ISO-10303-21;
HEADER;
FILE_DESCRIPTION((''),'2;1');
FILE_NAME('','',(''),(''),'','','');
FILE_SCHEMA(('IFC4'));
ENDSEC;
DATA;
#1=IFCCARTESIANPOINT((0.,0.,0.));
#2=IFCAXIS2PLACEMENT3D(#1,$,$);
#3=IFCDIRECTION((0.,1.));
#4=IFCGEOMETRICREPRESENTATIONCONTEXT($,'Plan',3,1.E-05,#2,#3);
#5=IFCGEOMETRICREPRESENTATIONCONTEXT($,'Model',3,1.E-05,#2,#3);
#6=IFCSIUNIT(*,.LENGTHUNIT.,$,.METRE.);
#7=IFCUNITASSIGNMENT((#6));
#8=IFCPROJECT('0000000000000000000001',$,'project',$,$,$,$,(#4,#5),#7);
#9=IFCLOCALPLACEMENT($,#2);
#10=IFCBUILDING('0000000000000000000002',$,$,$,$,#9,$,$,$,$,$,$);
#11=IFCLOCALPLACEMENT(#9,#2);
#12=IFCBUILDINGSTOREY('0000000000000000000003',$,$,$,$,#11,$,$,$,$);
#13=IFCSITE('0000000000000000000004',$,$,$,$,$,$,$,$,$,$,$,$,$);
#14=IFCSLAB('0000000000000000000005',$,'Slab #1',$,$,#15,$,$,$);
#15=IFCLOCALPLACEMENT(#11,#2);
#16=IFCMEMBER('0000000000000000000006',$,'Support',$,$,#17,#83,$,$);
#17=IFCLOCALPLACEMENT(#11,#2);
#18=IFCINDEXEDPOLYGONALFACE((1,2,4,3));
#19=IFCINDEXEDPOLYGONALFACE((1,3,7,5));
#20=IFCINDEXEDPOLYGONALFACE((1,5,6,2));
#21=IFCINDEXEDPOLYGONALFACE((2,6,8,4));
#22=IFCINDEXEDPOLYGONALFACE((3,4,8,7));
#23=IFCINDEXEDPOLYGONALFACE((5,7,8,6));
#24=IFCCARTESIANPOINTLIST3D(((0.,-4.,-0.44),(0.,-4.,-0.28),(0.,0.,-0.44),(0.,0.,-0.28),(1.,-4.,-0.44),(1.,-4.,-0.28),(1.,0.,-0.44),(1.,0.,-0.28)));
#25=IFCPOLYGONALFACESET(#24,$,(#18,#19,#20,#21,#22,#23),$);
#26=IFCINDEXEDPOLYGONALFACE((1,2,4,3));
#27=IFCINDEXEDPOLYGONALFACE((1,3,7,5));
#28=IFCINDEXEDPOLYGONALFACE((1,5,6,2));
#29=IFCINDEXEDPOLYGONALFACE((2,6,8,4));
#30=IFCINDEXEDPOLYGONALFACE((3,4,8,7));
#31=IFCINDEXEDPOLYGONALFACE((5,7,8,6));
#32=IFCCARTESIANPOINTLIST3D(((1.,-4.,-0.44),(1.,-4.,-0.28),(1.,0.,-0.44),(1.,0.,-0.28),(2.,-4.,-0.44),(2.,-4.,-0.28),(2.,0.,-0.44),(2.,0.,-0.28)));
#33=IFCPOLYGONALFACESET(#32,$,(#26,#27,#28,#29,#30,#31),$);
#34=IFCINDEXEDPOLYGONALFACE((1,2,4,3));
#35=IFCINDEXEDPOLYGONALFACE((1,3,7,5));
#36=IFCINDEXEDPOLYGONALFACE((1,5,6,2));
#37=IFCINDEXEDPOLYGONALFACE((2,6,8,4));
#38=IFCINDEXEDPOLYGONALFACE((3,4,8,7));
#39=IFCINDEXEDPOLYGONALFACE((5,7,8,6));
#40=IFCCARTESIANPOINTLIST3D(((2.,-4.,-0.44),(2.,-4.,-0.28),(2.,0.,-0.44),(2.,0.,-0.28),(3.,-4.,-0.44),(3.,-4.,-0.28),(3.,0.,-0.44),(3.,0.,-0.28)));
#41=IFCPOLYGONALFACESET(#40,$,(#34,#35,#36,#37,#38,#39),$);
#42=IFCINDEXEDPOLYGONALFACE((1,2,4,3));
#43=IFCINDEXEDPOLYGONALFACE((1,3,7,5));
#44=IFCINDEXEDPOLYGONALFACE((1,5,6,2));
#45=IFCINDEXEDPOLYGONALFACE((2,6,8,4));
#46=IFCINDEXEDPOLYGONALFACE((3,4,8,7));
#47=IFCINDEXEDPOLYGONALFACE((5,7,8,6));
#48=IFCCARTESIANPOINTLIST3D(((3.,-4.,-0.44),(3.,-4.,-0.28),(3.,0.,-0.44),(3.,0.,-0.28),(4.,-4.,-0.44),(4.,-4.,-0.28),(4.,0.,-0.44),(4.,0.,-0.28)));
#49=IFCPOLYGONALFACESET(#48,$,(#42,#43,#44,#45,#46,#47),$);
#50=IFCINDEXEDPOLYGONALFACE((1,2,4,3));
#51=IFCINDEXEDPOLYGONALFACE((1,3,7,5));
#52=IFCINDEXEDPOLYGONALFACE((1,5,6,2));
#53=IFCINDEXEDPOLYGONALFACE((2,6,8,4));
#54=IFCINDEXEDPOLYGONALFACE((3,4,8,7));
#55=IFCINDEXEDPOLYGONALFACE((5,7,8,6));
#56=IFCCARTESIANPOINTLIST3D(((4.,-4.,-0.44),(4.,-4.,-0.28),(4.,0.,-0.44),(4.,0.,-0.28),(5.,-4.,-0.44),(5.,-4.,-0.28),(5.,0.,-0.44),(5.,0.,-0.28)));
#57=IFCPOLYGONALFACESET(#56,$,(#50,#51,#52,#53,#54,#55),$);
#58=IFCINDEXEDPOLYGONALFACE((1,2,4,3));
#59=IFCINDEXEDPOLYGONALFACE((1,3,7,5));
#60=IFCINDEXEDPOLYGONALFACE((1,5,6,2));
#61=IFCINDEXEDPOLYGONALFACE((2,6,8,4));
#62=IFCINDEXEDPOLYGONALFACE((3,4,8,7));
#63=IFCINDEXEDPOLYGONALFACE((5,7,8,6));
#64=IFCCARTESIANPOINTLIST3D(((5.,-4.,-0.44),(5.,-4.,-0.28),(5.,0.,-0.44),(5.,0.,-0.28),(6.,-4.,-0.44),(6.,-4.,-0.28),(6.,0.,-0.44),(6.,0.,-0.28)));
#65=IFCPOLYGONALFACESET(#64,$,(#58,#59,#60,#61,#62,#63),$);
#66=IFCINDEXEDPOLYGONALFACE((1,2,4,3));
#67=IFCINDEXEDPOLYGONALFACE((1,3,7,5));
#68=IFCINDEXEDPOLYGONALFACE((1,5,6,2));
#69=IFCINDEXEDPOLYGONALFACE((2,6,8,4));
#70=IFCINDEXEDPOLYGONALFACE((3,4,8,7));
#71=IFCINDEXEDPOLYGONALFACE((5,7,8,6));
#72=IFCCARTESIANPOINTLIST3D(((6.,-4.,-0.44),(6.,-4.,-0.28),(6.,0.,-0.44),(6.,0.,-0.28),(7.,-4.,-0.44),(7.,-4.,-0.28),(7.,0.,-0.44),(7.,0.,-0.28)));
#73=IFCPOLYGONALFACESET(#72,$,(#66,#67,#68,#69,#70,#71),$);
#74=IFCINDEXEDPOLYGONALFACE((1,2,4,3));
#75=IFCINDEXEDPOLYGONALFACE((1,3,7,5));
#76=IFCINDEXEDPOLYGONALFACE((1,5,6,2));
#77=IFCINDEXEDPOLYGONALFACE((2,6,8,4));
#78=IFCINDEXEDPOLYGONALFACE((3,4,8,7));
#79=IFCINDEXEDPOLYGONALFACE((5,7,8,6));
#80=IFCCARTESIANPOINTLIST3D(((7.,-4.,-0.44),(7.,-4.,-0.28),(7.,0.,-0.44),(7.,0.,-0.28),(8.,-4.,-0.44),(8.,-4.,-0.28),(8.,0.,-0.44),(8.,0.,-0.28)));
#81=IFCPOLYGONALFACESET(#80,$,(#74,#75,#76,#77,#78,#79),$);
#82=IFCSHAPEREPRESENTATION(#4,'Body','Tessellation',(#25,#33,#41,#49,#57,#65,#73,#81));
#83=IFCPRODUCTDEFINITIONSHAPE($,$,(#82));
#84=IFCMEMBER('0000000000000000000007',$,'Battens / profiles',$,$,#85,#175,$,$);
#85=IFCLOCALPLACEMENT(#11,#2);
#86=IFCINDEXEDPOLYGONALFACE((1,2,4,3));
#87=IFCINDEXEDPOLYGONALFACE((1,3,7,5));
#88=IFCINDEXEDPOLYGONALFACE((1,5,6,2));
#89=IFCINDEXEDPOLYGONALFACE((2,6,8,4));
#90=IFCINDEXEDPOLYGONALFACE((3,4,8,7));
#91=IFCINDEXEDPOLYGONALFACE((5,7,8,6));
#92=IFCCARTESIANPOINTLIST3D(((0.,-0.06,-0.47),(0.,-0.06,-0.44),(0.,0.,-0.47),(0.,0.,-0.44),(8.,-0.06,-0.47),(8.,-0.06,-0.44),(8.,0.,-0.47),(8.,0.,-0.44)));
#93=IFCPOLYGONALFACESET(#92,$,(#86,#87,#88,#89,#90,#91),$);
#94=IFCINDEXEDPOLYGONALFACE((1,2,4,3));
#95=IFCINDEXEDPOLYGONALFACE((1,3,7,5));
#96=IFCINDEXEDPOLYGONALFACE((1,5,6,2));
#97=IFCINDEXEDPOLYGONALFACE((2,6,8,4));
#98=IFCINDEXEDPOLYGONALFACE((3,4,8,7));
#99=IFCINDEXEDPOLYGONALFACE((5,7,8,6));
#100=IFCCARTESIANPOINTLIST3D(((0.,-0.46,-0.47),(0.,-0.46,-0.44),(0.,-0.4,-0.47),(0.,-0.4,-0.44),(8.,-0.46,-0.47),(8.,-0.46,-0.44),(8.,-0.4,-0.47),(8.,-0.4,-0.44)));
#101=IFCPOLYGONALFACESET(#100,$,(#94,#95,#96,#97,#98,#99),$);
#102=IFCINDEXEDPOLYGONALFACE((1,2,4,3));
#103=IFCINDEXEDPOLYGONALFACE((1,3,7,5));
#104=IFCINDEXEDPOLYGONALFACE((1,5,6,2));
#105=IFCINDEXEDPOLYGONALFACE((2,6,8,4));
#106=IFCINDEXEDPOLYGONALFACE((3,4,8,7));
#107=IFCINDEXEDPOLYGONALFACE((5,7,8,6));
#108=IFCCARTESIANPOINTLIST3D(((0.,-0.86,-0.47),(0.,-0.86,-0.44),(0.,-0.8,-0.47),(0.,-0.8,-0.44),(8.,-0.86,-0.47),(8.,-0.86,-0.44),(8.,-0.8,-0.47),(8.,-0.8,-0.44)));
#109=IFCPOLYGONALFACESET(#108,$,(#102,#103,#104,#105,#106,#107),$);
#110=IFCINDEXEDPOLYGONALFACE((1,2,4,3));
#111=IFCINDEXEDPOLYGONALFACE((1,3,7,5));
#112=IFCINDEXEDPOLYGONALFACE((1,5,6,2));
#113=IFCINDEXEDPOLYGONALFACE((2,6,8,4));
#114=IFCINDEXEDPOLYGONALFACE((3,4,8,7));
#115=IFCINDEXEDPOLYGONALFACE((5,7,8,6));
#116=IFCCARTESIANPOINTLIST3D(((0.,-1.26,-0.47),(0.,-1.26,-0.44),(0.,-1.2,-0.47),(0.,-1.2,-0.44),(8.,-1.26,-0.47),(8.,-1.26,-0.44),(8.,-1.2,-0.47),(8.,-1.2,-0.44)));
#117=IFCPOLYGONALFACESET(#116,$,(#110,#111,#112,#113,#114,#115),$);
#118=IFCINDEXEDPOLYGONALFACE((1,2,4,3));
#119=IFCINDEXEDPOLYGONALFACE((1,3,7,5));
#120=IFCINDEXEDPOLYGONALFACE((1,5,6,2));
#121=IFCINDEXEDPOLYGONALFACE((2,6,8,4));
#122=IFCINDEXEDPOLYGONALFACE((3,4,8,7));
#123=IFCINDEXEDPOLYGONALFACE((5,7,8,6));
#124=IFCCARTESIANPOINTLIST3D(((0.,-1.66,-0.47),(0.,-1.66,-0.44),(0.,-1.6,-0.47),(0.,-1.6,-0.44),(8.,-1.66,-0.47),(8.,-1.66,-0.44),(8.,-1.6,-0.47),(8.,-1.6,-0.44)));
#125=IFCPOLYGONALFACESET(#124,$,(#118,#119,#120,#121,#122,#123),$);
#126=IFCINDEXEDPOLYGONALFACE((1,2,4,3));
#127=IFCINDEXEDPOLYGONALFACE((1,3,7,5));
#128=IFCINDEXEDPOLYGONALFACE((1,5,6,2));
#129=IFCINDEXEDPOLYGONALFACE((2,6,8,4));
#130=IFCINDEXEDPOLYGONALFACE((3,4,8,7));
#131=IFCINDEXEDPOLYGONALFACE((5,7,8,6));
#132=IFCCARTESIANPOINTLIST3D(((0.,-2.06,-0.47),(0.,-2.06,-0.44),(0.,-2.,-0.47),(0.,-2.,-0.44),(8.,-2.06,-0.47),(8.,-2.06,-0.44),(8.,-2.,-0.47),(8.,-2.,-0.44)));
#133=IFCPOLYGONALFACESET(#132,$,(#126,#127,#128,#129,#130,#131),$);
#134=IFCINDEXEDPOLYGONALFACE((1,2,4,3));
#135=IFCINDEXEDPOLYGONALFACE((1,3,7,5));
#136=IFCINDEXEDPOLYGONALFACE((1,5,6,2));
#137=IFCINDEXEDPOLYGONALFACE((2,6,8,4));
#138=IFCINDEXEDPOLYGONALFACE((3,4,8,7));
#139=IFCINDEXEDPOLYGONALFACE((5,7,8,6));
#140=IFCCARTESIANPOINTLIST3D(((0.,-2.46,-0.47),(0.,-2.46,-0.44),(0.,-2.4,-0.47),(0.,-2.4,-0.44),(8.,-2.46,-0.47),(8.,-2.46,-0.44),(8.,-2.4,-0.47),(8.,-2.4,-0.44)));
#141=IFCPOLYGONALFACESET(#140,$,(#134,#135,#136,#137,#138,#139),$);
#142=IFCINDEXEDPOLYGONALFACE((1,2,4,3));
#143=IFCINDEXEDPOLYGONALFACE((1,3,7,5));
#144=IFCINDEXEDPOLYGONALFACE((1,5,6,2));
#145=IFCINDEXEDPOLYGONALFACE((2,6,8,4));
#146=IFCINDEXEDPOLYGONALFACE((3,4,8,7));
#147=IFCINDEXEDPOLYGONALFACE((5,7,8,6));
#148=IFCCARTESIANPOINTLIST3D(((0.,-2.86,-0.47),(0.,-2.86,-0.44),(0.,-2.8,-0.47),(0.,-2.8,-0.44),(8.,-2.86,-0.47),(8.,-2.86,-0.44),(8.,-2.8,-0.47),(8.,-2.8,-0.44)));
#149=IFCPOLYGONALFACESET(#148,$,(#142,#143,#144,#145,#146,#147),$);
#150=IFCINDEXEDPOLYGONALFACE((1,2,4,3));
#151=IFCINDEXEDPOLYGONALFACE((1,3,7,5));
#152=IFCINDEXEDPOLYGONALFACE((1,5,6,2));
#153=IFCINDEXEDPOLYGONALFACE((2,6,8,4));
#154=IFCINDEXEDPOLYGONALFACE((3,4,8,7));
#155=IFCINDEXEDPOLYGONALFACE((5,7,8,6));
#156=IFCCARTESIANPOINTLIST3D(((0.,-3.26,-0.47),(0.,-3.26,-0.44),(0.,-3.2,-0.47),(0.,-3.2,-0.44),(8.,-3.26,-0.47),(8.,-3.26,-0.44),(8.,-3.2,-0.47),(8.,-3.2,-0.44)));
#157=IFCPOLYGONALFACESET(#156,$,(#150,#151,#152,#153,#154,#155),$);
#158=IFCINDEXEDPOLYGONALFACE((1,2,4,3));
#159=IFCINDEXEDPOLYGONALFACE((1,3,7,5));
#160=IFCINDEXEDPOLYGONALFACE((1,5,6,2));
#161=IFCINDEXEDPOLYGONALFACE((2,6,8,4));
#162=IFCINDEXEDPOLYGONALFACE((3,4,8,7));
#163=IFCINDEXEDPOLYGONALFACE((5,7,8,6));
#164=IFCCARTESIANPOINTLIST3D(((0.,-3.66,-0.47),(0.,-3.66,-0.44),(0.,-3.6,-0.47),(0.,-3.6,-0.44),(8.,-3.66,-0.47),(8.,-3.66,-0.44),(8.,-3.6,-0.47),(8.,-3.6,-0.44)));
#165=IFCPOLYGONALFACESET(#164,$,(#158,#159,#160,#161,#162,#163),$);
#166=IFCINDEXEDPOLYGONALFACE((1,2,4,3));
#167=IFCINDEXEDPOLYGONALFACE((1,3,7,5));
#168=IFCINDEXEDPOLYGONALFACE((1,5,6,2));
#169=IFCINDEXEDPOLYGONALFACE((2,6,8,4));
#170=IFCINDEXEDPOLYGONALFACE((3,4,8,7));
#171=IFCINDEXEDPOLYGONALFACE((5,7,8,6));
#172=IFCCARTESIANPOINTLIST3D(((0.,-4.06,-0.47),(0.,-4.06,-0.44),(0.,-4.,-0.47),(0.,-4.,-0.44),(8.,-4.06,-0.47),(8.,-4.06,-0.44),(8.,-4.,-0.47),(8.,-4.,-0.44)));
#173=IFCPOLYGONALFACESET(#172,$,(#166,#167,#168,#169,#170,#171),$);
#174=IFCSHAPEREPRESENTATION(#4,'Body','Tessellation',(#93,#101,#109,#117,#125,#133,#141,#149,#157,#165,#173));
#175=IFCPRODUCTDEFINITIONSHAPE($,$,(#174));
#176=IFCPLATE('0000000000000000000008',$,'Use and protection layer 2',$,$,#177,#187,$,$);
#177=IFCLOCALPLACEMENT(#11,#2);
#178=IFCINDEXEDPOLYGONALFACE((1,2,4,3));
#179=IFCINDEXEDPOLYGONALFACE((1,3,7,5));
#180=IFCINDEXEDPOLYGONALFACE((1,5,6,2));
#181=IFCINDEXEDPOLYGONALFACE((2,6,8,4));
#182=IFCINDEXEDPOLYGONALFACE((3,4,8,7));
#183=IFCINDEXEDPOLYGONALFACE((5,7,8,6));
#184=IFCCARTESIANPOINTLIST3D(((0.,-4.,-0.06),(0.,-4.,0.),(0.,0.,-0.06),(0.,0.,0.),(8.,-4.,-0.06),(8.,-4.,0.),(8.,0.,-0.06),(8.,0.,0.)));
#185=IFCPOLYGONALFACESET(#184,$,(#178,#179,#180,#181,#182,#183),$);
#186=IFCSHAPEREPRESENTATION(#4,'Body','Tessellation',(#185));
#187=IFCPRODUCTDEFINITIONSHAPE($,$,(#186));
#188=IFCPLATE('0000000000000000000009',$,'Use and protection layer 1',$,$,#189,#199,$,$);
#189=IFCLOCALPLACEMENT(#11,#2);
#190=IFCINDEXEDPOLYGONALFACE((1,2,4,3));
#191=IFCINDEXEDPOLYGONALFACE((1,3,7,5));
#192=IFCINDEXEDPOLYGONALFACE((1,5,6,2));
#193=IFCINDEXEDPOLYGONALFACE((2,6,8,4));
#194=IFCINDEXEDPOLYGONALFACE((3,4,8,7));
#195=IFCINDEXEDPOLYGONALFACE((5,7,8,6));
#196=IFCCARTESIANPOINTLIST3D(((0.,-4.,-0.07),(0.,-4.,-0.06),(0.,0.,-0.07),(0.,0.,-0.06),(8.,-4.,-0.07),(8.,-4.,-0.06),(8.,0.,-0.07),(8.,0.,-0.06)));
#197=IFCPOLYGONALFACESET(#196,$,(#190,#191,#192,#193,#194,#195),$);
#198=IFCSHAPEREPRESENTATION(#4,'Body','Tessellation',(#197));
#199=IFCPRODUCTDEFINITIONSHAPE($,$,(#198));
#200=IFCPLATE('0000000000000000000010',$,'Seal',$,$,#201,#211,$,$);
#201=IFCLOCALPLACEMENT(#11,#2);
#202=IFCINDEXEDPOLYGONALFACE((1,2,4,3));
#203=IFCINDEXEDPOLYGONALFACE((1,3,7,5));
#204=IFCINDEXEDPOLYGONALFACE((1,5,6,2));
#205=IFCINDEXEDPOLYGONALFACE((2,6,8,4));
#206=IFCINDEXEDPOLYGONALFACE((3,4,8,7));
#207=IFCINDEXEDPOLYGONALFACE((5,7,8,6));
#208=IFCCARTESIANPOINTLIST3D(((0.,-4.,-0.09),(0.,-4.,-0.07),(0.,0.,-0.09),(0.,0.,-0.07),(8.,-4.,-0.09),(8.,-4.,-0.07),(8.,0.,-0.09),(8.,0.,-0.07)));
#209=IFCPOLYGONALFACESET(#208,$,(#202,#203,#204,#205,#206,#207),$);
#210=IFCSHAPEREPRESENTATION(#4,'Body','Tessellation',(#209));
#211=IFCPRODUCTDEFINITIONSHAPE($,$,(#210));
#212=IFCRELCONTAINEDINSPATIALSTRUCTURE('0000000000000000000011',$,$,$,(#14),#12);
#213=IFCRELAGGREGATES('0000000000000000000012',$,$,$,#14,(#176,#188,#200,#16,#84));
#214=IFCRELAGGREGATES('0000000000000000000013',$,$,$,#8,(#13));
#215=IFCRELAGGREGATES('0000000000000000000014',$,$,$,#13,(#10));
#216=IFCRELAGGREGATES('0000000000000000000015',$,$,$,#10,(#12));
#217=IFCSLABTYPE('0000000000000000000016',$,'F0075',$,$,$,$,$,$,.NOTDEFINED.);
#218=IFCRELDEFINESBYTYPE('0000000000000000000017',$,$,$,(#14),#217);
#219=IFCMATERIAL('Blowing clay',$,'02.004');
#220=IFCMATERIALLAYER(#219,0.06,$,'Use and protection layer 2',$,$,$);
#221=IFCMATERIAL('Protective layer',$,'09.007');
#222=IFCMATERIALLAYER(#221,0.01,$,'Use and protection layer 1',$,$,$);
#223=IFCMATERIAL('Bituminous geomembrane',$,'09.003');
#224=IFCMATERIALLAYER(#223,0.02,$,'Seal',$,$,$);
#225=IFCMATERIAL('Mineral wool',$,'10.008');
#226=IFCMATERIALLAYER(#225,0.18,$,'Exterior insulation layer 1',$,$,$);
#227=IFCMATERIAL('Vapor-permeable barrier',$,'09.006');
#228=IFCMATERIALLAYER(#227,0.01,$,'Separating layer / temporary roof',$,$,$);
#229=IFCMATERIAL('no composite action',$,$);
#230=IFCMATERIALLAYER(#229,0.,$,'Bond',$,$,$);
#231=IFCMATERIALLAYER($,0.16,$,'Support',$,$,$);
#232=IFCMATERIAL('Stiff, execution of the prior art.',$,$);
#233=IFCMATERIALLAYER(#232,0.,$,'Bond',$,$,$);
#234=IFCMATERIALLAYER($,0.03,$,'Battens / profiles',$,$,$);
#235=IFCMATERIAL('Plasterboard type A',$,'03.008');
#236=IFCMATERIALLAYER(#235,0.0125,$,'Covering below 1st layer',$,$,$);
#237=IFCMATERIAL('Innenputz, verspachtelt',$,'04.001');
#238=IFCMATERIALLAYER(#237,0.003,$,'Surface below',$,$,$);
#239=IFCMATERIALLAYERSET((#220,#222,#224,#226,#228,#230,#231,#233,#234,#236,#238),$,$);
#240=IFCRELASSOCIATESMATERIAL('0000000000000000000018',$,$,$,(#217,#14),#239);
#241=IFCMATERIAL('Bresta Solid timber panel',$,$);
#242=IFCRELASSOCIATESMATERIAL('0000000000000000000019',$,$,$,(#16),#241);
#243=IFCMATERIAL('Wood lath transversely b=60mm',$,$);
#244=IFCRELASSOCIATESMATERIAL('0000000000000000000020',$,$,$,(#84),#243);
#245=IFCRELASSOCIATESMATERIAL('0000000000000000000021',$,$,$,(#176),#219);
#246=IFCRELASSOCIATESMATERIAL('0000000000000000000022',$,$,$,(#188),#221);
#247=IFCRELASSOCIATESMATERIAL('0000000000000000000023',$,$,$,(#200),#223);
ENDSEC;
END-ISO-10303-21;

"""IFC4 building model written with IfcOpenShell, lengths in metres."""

from ifc_helpers import new_model, si_unit, direction, frame, frame_2d, origin, origin_with_axes, place, context, project, spatial, rectangle, extrude, material, layer, layer_set, type_object, element, aggregate, save


model = new_model("IFC4")

# Units and contexts
plan_context = context("Plan", 3, precision=1e-05, world=origin(), true_north=direction((0.0, 1.0)))
model_context = context("Model", 3, precision=1e-05, world=origin(), true_north=direction((0.0, 1.0)))
ifc_project = project(units=[si_unit("LENGTHUNIT", "METRE")], contexts=[plan_context, model_context])

# Site, building, storey
site = spatial("IfcSite", under=ifc_project)
building_placement = place(None, origin())
building = spatial("IfcBuilding", under=site, at=building_placement)
storey_placement = place(building_placement, origin())
storey = spatial("IfcBuildingStorey", under=building, at=storey_placement)

# Slab, members, plates
ifc_material_1 = material(Name="Blowing clay", Category="02.004")
ifc_layer_1 = layer(ifc_material_1, 0.06, Name="Use and protection layer 2")
ifc_material_2 = material(Name="Protective layer", Category="09.007")
ifc_layer_2 = layer(ifc_material_2, 0.01, Name="Use and protection layer 1")
ifc_material_3 = material(Name="Bituminous geomembrane", Category="09.003")
ifc_layer_3 = layer(ifc_material_3, 0.02, Name="Seal")
ifc_material_4 = material(Name="Mineral wool", Category="10.008")
ifc_layer_4 = layer(ifc_material_4, 0.18, Name="Exterior insulation layer 1")
ifc_material_5 = material(Name="Vapor-permeable barrier", Category="09.006")
ifc_layer_5 = layer(ifc_material_5, 0.01, Name="Separating layer / temporary roof")
ifc_material_6 = material(Name="no composite action")
ifc_layer_6 = layer(ifc_material_6, 0.0, Name="Bond")
ifc_layer_7 = layer(None, 0.16, Name="Support")
ifc_material_7 = material(Name="Stiff, execution of the prior art.")
ifc_layer_8 = layer(ifc_material_7, 0.0, Name="Bond")
ifc_layer_9 = layer(None, 0.03, Name="Battens / profiles")
ifc_material_8 = material(Name="Plasterboard type A", Category="03.008")
ifc_layer_10 = layer(ifc_material_8, 0.0125, Name="Covering below 1st layer")
ifc_material_9 = material(Name="Innenputz, verspachtelt", Category="04.001")
ifc_layer_11 = layer(ifc_material_9, 0.003, Name="Surface below")
ifc_layer_set = layer_set([ifc_layer_1, ifc_layer_2, ifc_layer_3, ifc_layer_4, ifc_layer_5, ifc_layer_6, ifc_layer_7, ifc_layer_8, ifc_layer_9, ifc_layer_10, ifc_layer_11])
slab_type = type_object("IfcSlabType", Name="F0075", PredefinedType="NOTDEFINED", material=ifc_layer_set)
slab_placement = place(None, frame((0.0, 0.0, 0.0), z_axis=(0.0, 0.0, -1.0), x_axis=(1.0, 0.0, 0.0)))
slab = element("IfcSlab", 1, at=slab_placement, inside=storey, type_object=slab_type, material=ifc_layer_set, Name="Slab #1")
ifc_material_10 = material(Name="Bresta Solid timber panel")
member_1_placement = place(slab_placement, origin())
member_1 = element("IfcMember", 2, at=member_1_placement, material=ifc_material_10, Name="Support", context=plan_context, shape_type="SweptSolid", body=[
    extrude(rectangle(XDim=1.0, YDim=0.16, at=frame_2d((0.5, 0.08), x_axis=(1.0, 0.0))), frame((0.0, 4.0, 0.28), z_axis=(0.0, -1.0, 0.0), x_axis=(1.0, 0.0, 0.0)), (0.0, 0.0, 1.0), 4.0),
    extrude(rectangle(XDim=1.0, YDim=0.16, at=frame_2d((0.5, 0.08), x_axis=(1.0, 0.0))), frame((1.0, 4.0, 0.28), z_axis=(0.0, -1.0, 0.0), x_axis=(1.0, 0.0, 0.0)), (0.0, 0.0, 1.0), 4.0),
    extrude(rectangle(XDim=1.0, YDim=0.16, at=frame_2d((0.5, 0.08), x_axis=(1.0, 0.0))), frame((2.0, 4.0, 0.28), z_axis=(0.0, -1.0, 0.0), x_axis=(1.0, 0.0, 0.0)), (0.0, 0.0, 1.0), 4.0),
    extrude(rectangle(XDim=1.0, YDim=0.16, at=frame_2d((0.5, 0.08), x_axis=(1.0, 0.0))), frame((3.0, 4.0, 0.28), z_axis=(0.0, -1.0, 0.0), x_axis=(1.0, 0.0, 0.0)), (0.0, 0.0, 1.0), 4.0),
    extrude(rectangle(XDim=1.0, YDim=0.16, at=frame_2d((0.5, 0.08), x_axis=(1.0, 0.0))), frame((4.0, 4.0, 0.28), z_axis=(0.0, -1.0, 0.0), x_axis=(1.0, 0.0, 0.0)), (0.0, 0.0, 1.0), 4.0),
    extrude(rectangle(XDim=1.0, YDim=0.16, at=frame_2d((0.5, 0.08), x_axis=(1.0, 0.0))), frame((5.0, 4.0, 0.28), z_axis=(0.0, -1.0, 0.0), x_axis=(1.0, 0.0, 0.0)), (0.0, 0.0, 1.0), 4.0),
    extrude(rectangle(XDim=1.0, YDim=0.16, at=frame_2d((0.5, 0.08), x_axis=(1.0, 0.0))), frame((6.0, 4.0, 0.28), z_axis=(0.0, -1.0, 0.0), x_axis=(1.0, 0.0, 0.0)), (0.0, 0.0, 1.0), 4.0),
    extrude(rectangle(XDim=1.0, YDim=0.16, at=frame_2d((0.5, 0.08), x_axis=(1.0, 0.0))), frame((7.0, 4.0, 0.28), z_axis=(0.0, -1.0, 0.0), x_axis=(1.0, 0.0, 0.0)), (0.0, 0.0, 1.0), 4.0),
])
ifc_material_11 = material(Name="Wood lath transversely b=60mm")
member_2_placement = place(slab_placement, origin())
member_2 = element("IfcMember", 3, at=member_2_placement, material=ifc_material_11, Name="Battens / profiles", context=plan_context, shape_type="SweptSolid", body=[
    extrude(rectangle(XDim=0.06, YDim=0.03, at=frame_2d((0.03, 0.015), x_axis=(1.0, 0.0))), frame((0.0, 0.0, 0.44), z_axis=(1.0, 0.0, 0.0), x_axis=(0.0, 1.0, 0.0)), (0.0, 0.0, 1.0), 8.0),
    extrude(rectangle(XDim=0.06, YDim=0.03, at=frame_2d((0.03, 0.015), x_axis=(1.0, 0.0))), frame((0.0, 0.4, 0.44), z_axis=(1.0, 0.0, 0.0), x_axis=(0.0, 1.0, 0.0)), (0.0, 0.0, 1.0), 8.0),
    extrude(rectangle(XDim=0.06, YDim=0.03, at=frame_2d((0.03, 0.015), x_axis=(1.0, 0.0))), frame((0.0, 0.8, 0.44), z_axis=(1.0, 0.0, 0.0), x_axis=(0.0, 1.0, 0.0)), (0.0, 0.0, 1.0), 8.0),
    extrude(rectangle(XDim=0.06, YDim=0.03, at=frame_2d((0.03, 0.015), x_axis=(1.0, 0.0))), frame((0.0, 1.2, 0.44), z_axis=(1.0, 0.0, 0.0), x_axis=(0.0, 1.0, 0.0)), (0.0, 0.0, 1.0), 8.0),
    extrude(rectangle(XDim=0.06, YDim=0.03, at=frame_2d((0.03, 0.015), x_axis=(1.0, 0.0))), frame((0.0, 1.6, 0.44), z_axis=(1.0, 0.0, 0.0), x_axis=(0.0, 1.0, 0.0)), (0.0, 0.0, 1.0), 8.0),
    extrude(rectangle(XDim=0.06, YDim=0.03, at=frame_2d((0.03, 0.015), x_axis=(1.0, 0.0))), frame((0.0, 2.0, 0.44), z_axis=(1.0, 0.0, 0.0), x_axis=(0.0, 1.0, 0.0)), (0.0, 0.0, 1.0), 8.0),
    extrude(rectangle(XDim=0.06, YDim=0.03, at=frame_2d((0.03, 0.015), x_axis=(1.0, 0.0))), frame((0.0, 2.4, 0.44), z_axis=(1.0, 0.0, 0.0), x_axis=(0.0, 1.0, 0.0)), (0.0, 0.0, 1.0), 8.0),
    extrude(rectangle(XDim=0.06, YDim=0.03, at=frame_2d((0.03, 0.015), x_axis=(1.0, 0.0))), frame((0.0, 2.8, 0.44), z_axis=(1.0, 0.0, 0.0), x_axis=(0.0, 1.0, 0.0)), (0.0, 0.0, 1.0), 8.0),
    extrude(rectangle(XDim=0.06, YDim=0.03, at=frame_2d((0.03, 0.015), x_axis=(1.0, 0.0))), frame((0.0, 3.2, 0.44), z_axis=(1.0, 0.0, 0.0), x_axis=(0.0, 1.0, 0.0)), (0.0, 0.0, 1.0), 8.0),
    extrude(rectangle(XDim=0.06, YDim=0.03, at=frame_2d((0.03, 0.015), x_axis=(1.0, 0.0))), frame((0.0, 3.6, 0.44), z_axis=(1.0, 0.0, 0.0), x_axis=(0.0, 1.0, 0.0)), (0.0, 0.0, 1.0), 8.0),
    extrude(rectangle(XDim=0.06, YDim=0.03, at=frame_2d((0.03, 0.015), x_axis=(1.0, 0.0))), frame((0.0, 4.0, 0.44), z_axis=(1.0, 0.0, 0.0), x_axis=(0.0, 1.0, 0.0)), (0.0, 0.0, 1.0), 8.0),
])
plate_1_placement = place(slab_placement, origin())
plate_1 = element("IfcPlate", 4, at=plate_1_placement, material=ifc_material_1, Name="Use and protection layer 2", context=plan_context, shape_type="SweptSolid", body=[
    extrude(rectangle(XDim=8.0, YDim=4.0, at=frame_2d((4.0, 2.0), x_axis=(1.0, 0.0))), origin_with_axes(), (0.0, 0.0, 1.0), 0.06),
])
plate_2_placement = place(slab_placement, origin())
plate_2 = element("IfcPlate", 5, at=plate_2_placement, material=ifc_material_2, Name="Use and protection layer 1", context=plan_context, shape_type="SweptSolid", body=[
    extrude(rectangle(XDim=8.0, YDim=4.0, at=frame_2d((4.0, 2.0), x_axis=(1.0, 0.0))), frame((0.0, 0.0, 0.06), z_axis=(0.0, 0.0, 1.0), x_axis=(1.0, 0.0, 0.0)), (0.0, 0.0, 1.0), 0.01),
])
plate_3_placement = place(slab_placement, origin())
plate_3 = element("IfcPlate", 6, at=plate_3_placement, material=ifc_material_3, Name="Seal", context=plan_context, shape_type="SweptSolid", body=[
    extrude(rectangle(XDim=8.0, YDim=4.0, at=frame_2d((4.0, 2.0), x_axis=(1.0, 0.0))), frame((0.0, 0.0, 0.07), z_axis=(0.0, 0.0, 1.0), x_axis=(1.0, 0.0, 0.0)), (0.0, 0.0, 1.0), 0.02),
])
aggregate(slab, [plate_1, plate_2, plate_3, member_1, member_2])

save(model, "model.ifc")
